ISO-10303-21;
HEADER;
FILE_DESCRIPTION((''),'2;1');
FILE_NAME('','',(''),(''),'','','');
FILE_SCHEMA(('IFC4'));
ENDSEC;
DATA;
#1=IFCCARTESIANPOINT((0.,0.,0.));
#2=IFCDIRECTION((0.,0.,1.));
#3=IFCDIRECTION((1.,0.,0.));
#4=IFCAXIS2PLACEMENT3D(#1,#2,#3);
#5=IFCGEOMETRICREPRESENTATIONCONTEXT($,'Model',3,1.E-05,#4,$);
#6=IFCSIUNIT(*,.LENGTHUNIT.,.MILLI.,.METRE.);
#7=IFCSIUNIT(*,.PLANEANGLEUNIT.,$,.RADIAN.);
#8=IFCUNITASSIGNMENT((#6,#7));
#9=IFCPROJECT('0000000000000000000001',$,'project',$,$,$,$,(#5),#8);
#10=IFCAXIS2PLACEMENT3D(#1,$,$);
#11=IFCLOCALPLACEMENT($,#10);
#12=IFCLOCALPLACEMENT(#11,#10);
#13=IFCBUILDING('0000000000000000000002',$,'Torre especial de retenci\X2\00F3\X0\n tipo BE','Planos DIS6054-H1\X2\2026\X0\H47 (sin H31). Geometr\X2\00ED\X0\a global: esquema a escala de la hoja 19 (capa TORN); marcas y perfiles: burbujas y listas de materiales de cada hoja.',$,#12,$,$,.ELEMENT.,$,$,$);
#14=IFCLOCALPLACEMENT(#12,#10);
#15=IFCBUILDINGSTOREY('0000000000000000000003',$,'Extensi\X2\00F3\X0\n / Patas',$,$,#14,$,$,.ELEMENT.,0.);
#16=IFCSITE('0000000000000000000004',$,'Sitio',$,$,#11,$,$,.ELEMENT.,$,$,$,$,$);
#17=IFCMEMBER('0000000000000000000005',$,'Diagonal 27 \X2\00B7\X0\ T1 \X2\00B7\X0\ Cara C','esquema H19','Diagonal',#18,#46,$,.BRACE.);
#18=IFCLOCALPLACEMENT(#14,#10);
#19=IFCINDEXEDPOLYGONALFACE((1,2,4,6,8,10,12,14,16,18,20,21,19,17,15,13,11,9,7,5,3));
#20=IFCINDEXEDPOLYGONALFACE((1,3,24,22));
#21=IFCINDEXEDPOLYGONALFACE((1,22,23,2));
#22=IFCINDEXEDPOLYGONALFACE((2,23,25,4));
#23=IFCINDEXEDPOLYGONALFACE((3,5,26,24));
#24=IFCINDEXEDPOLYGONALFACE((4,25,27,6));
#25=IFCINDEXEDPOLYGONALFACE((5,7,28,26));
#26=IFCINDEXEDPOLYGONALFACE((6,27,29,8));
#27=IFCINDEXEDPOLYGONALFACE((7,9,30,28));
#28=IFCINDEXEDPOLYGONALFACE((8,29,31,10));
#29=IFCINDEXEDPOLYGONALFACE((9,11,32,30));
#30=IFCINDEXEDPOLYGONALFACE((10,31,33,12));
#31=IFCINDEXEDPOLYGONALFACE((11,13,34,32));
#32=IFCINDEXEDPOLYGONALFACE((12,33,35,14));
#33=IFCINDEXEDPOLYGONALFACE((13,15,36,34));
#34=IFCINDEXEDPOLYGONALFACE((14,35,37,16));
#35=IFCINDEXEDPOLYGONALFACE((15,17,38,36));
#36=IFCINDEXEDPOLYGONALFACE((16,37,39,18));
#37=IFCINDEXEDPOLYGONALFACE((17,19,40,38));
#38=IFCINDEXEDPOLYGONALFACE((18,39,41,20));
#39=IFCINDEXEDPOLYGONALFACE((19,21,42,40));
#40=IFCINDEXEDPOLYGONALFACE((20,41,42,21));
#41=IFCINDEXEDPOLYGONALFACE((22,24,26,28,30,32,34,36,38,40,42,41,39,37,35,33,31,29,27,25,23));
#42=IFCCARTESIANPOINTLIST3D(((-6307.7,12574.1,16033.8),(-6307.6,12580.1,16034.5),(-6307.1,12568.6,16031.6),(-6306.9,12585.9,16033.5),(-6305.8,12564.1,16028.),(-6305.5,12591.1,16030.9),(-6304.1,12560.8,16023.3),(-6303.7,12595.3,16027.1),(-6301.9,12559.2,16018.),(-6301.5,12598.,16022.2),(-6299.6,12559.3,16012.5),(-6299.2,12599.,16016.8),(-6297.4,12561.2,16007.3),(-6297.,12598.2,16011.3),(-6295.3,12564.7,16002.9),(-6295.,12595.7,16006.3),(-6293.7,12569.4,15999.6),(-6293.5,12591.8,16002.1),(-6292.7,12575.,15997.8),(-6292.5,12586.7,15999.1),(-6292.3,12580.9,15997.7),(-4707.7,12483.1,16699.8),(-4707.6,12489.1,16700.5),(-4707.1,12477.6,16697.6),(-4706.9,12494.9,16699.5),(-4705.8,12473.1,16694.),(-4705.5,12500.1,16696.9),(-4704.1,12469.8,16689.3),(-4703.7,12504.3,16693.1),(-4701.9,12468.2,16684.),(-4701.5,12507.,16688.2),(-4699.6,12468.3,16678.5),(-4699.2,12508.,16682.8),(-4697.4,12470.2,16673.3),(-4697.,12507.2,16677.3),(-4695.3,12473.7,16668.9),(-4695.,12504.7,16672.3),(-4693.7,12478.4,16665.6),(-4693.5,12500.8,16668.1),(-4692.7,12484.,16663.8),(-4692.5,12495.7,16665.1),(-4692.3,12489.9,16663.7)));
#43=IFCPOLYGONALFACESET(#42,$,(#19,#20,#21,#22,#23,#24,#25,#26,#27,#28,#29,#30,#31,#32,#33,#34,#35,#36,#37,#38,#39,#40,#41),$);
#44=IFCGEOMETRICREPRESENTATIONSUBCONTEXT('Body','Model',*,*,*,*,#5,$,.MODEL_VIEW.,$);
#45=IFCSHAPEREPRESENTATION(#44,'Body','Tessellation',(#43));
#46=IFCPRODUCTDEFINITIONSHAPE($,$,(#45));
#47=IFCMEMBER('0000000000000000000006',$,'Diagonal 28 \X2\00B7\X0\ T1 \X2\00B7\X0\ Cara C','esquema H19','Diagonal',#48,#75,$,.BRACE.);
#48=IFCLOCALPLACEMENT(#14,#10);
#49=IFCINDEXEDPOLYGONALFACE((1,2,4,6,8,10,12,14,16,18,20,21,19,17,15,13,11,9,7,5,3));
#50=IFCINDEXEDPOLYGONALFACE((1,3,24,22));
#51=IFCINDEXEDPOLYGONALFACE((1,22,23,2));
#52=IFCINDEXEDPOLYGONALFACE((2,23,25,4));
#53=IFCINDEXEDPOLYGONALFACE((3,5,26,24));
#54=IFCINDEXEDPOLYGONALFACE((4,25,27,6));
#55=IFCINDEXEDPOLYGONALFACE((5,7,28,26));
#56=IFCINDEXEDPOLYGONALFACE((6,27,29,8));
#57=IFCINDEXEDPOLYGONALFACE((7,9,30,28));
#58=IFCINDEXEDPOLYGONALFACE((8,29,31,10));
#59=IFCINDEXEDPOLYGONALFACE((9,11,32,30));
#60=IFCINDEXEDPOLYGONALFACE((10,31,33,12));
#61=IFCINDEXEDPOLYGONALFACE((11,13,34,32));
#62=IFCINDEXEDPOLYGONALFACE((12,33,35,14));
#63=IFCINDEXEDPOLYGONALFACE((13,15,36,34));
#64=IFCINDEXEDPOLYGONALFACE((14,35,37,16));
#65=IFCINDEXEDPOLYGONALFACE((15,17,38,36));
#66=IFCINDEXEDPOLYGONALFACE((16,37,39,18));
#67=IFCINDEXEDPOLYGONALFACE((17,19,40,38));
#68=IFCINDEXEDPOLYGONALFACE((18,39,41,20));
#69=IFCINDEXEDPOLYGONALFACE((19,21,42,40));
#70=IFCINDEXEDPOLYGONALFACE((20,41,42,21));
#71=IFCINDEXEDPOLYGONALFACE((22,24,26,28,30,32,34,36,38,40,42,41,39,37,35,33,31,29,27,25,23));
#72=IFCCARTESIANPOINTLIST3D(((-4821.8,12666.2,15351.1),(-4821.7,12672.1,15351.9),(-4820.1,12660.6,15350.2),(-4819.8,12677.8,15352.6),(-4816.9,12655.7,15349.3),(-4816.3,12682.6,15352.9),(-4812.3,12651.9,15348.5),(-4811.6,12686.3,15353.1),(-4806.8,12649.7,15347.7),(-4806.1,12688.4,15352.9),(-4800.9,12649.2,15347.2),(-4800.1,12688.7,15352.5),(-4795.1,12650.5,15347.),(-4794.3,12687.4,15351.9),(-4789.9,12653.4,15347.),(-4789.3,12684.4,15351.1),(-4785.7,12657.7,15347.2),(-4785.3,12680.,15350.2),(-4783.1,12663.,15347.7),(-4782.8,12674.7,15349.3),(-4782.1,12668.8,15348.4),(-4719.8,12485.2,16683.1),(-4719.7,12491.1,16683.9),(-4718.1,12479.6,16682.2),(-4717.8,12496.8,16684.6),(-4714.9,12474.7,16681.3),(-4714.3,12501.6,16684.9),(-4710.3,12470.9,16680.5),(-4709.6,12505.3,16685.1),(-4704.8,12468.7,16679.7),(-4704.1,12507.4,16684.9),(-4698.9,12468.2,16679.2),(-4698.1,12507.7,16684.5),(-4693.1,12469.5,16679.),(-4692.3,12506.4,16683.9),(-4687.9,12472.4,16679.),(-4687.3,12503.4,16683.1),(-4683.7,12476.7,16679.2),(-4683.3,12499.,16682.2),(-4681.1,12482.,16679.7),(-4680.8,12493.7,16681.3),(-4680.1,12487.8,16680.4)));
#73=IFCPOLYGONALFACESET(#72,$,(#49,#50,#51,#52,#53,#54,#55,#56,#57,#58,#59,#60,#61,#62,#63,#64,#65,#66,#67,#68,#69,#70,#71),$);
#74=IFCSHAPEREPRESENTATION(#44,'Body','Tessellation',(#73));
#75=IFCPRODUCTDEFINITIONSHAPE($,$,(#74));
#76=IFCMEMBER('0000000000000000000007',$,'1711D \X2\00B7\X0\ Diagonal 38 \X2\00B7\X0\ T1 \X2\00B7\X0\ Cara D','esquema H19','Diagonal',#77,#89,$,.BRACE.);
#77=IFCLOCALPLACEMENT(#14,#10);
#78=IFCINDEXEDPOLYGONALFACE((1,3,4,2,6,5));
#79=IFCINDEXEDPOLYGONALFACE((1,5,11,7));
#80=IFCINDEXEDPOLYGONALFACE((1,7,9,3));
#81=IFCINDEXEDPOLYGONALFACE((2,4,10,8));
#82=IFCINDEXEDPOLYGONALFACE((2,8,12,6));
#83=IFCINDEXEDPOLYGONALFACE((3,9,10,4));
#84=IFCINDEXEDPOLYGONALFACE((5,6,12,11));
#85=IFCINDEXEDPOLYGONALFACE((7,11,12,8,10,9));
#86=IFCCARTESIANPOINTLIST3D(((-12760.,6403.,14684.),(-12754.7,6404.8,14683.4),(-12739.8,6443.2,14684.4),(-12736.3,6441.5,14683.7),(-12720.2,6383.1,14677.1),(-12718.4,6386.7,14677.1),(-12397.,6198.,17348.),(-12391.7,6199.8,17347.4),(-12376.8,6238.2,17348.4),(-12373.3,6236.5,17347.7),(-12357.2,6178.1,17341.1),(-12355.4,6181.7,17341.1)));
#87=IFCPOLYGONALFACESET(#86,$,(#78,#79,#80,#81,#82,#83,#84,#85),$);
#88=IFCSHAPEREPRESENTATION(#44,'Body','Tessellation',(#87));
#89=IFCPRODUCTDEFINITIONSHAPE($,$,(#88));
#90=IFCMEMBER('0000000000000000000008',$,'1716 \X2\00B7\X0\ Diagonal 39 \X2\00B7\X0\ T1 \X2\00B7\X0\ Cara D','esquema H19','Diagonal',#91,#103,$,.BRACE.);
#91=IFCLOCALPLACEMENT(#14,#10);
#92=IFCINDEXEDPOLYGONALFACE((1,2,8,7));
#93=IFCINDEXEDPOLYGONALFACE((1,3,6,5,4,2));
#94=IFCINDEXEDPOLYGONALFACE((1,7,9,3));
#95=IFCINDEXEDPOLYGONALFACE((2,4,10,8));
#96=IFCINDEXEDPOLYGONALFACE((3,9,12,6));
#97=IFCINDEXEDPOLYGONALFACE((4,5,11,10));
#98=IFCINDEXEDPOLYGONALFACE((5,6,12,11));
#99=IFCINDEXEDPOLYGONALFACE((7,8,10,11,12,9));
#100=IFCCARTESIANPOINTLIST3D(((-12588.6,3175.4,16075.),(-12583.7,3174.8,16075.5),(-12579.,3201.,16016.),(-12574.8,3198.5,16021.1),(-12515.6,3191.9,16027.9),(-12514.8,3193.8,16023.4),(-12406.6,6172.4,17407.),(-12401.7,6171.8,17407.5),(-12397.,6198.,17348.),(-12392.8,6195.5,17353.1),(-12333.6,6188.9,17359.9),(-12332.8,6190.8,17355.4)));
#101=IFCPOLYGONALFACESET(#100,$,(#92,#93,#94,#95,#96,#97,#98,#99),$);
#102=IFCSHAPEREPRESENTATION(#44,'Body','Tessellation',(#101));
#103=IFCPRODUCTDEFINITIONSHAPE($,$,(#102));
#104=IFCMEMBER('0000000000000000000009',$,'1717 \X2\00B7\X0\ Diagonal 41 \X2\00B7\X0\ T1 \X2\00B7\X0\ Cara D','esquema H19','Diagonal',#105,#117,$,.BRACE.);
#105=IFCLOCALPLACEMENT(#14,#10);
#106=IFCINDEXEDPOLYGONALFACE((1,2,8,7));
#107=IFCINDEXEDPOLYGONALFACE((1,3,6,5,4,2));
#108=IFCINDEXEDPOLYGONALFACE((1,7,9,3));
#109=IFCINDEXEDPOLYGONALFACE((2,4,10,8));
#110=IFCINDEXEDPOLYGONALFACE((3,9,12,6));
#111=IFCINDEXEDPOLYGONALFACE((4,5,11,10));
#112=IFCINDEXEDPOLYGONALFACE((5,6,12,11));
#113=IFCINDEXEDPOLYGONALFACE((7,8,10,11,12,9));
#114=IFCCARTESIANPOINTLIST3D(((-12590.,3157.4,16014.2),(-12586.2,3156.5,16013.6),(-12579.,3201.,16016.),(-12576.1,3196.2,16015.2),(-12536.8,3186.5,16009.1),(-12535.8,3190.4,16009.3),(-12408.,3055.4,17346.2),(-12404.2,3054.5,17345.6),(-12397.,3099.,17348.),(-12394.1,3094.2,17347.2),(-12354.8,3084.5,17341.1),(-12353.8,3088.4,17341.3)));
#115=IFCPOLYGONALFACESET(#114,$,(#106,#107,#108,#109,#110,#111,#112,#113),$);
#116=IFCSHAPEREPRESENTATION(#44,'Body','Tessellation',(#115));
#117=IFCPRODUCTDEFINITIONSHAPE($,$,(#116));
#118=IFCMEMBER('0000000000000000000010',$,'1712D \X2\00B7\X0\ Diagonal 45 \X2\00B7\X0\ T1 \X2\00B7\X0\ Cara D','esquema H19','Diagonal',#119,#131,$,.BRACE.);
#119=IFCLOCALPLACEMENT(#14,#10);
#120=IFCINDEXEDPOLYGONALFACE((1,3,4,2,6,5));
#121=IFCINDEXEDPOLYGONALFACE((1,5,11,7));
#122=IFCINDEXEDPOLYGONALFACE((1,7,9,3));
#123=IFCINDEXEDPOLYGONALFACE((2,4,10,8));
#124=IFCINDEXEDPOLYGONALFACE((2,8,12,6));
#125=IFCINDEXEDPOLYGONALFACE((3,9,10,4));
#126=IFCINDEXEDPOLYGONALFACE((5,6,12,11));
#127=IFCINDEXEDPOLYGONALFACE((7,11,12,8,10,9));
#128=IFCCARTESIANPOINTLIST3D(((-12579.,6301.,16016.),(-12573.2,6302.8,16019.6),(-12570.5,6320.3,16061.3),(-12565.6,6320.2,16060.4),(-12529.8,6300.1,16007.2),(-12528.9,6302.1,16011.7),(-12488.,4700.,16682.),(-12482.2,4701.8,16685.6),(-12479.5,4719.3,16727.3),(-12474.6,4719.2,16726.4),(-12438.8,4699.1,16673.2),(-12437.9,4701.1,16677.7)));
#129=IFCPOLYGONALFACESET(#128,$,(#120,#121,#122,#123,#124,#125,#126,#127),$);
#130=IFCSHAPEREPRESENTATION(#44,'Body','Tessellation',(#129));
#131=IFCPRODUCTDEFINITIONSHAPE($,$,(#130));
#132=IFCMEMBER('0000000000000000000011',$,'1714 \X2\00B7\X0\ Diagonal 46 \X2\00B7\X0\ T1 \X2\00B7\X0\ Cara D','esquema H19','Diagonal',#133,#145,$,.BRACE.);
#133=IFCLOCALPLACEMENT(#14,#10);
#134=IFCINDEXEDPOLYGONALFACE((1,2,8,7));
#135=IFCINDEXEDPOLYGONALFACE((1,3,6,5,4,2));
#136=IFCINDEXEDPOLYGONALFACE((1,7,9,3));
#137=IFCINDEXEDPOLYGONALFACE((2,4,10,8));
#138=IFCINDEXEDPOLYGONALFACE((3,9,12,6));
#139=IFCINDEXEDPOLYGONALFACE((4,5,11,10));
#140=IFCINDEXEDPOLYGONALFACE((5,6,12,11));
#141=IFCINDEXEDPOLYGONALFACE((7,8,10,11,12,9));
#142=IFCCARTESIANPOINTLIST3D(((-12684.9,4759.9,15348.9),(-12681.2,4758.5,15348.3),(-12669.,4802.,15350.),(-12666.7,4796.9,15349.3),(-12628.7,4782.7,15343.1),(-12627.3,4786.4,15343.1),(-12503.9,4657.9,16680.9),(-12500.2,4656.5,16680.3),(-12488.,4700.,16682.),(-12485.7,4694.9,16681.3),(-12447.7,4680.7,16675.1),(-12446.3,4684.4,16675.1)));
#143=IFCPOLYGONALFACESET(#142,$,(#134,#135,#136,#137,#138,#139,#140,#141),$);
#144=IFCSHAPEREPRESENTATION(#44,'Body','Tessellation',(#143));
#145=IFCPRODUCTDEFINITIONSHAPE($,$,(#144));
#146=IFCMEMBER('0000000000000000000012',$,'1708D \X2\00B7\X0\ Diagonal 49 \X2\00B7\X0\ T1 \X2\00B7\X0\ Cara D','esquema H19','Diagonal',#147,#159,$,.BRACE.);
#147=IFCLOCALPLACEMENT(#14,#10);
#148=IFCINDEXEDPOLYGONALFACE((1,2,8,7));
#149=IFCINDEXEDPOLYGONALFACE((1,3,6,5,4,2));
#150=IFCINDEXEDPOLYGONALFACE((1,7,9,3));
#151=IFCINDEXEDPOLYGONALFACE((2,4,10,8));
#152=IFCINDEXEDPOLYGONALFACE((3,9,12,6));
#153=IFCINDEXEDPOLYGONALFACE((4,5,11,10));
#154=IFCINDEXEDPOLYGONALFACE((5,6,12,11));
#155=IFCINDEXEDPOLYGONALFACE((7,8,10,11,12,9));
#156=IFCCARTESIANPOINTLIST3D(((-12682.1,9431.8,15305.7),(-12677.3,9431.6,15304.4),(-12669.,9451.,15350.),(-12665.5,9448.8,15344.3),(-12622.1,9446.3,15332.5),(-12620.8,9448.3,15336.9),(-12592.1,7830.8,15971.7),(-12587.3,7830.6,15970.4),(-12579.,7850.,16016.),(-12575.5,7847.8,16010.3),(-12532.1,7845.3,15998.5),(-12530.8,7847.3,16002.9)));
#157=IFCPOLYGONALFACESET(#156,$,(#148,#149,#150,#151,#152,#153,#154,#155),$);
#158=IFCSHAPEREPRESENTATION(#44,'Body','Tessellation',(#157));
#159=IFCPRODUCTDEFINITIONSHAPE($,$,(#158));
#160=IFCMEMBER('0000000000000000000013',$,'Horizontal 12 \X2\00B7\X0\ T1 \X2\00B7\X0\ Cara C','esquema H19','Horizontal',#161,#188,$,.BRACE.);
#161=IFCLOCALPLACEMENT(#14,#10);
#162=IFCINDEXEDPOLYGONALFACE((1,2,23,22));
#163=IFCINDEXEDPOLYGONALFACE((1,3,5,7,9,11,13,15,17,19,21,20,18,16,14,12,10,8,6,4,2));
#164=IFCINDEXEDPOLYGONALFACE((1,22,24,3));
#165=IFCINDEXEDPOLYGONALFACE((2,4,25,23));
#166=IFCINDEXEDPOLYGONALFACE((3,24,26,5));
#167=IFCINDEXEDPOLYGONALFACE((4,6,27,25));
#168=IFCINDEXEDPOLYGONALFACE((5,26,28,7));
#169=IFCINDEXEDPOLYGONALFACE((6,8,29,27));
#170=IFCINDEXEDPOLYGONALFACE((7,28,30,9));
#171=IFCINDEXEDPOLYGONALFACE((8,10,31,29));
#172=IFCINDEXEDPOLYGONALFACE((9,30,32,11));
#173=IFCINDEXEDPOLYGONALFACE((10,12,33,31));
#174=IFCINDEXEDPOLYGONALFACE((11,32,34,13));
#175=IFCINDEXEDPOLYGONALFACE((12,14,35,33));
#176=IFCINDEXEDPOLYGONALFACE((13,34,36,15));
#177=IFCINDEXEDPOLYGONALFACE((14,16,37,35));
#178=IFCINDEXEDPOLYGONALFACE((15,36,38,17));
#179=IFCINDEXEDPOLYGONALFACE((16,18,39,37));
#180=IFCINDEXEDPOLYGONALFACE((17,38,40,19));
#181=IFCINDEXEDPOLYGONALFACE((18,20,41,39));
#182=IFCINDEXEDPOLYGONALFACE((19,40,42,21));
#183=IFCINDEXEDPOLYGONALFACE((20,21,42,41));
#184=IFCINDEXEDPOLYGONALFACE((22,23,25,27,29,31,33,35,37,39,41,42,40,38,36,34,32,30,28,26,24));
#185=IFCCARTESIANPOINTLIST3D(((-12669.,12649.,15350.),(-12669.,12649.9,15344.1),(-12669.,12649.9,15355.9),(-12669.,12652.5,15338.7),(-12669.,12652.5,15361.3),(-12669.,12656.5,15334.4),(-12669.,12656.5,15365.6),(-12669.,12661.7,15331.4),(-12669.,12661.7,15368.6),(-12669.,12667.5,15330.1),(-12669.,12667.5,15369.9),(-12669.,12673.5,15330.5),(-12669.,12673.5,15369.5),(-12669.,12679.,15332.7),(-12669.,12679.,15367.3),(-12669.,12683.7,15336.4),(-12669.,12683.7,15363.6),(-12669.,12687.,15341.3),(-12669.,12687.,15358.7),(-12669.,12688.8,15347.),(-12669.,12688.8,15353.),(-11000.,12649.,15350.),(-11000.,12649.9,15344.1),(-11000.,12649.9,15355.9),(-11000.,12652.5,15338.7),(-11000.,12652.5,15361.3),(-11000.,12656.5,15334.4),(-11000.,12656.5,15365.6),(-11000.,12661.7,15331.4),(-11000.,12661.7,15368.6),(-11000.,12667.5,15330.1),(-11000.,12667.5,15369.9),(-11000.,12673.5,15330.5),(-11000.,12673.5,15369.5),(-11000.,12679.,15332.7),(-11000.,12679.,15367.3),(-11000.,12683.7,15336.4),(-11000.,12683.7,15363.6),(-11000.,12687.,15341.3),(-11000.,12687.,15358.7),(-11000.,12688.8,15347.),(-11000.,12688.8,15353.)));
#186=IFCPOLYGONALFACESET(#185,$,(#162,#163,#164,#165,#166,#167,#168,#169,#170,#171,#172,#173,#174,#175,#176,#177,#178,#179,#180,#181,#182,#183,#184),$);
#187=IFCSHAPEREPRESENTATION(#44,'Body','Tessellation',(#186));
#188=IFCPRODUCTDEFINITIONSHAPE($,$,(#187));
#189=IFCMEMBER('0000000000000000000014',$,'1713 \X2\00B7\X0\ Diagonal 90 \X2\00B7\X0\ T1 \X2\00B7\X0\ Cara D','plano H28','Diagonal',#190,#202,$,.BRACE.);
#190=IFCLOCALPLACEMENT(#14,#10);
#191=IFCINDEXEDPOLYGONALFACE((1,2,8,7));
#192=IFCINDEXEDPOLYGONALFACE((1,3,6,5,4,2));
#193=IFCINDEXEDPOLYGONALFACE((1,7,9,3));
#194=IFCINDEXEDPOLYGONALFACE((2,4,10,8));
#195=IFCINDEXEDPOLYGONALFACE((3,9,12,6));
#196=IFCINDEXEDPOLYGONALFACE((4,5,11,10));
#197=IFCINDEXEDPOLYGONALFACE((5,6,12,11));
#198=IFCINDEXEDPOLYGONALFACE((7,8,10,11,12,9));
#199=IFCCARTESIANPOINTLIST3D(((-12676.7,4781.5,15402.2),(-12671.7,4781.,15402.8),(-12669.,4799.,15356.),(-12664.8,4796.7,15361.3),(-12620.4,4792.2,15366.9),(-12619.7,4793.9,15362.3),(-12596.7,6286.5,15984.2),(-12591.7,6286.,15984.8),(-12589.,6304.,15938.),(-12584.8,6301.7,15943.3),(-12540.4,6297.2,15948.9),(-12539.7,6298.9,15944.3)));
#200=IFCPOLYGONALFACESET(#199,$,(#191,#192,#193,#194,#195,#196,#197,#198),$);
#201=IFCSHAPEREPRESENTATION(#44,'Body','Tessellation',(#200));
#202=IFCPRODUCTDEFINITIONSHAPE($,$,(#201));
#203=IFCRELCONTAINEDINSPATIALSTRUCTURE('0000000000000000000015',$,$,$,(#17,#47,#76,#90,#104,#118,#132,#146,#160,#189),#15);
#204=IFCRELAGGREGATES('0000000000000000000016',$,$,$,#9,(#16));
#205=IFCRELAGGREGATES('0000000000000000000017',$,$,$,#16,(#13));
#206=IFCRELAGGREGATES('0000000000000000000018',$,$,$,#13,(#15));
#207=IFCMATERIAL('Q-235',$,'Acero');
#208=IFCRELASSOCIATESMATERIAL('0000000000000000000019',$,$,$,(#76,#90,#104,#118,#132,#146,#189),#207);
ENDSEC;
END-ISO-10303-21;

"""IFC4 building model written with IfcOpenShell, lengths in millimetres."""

from ifc_helpers import new_model, si_unit, frame, frame_2d, origin, origin_with_axes, place, context, subcontext, project, spatial, circle, l_section, extrude, material, element, save


model = new_model("IFC4")

# Units and contexts
model_context = context("Model", 3, precision=1e-05, world=origin_with_axes())
body_context = subcontext(model_context, "Body", "Model", "MODEL_VIEW")
ifc_project = project(units=[si_unit("LENGTHUNIT", "METRE", prefix="MILLI"), si_unit("PLANEANGLEUNIT", "RADIAN")], contexts=[model_context])

# Site, building, storey
site_placement = place(None, origin())
site = spatial("IfcSite", under=ifc_project, at=site_placement, Name="Sitio", CompositionType="ELEMENT")
building_placement = place(site_placement, origin())
building = spatial("IfcBuilding", under=site, at=building_placement, Name="Torre especial de retención tipo BE", Description="Planos DIS6054-H1…H47 (sin H31). Geometría global: esquema a escala de la hoja 19 (capa TORN); marcas y perfiles: burbujas y listas de materiales de cada hoja.", CompositionType="ELEMENT")
storey_placement = place(building_placement, origin())
storey = spatial("IfcBuildingStorey", under=building, at=storey_placement, Name="Extensión / Patas", CompositionType="ELEMENT", Elevation=0.0)

# Members
ifc_material = material(Name="Q-235", Category="Acero")
member_1_placement = place(storey_placement, frame((-6300.0, 12579.0, 16016.0), z_axis=(0.921943, -0.052436, 0.383759), x_axis=(0.017634, -0.984084, -0.176826)))
element("IfcMember", 1, at=member_1_placement, inside=storey, Name="Diagonal 27 · T1 · Cara C", Description="esquema H19", ObjectType="Diagonal", PredefinedType="BRACE", context=body_context, shape_type="SweptSolid", body=[
    extrude(circle(Radius=20.0), None, (0.0, 0.0, 1.0), 1735.5),
])
member_2_placement = place(storey_placement, frame((-4700.0, 12488.0, 16682.0), z_axis=(-0.075662, 0.134262, -0.988053), x_axis=(0.345854, -0.925846, -0.152294)))
element("IfcMember", 2, at=member_2_placement, inside=storey, Name="Diagonal 28 · T1 · Cara C", Description="esquema H19", ObjectType="Diagonal", PredefinedType="BRACE", context=body_context, shape_type="SweptSolid", body=[
    extrude(circle(Radius=20.0), None, (0.0, 0.0, 1.0), 1348.1),
])
member_3_placement = place(storey_placement, frame((-12760.0, 6403.0, 14684.0), z_axis=(0.134623, -0.076027, 0.987976), x_axis=(0.883921, -0.441408, -0.154411)))
element("IfcMember", 3, at=member_3_placement, inside=storey, material=ifc_material, Name="1711D · Diagonal 38 · T1 · Cara D", Description="esquema H19", ObjectType="Diagonal", PredefinedType="BRACE", context=body_context, shape_type="SweptSolid", body=[
    extrude(l_section(Depth=45.0, Width=45.0, Thickness=4.0, at=frame_2d((22.5, 22.5))), None, (0.0, 0.0, 1.0), 2696.4),
])
member_4_placement = place(storey_placement, frame((-12397.0, 6198.0, 17348.0), z_axis=(-0.055408, -0.912408, -0.405515), x_axis=(0.987387, -0.110399, 0.113485)))
element("IfcMember", 4, at=member_4_placement, inside=storey, material=ifc_material, Name="1716 · Diagonal 39 · T1 · Cara D", Description="esquema H19", ObjectType="Diagonal", PredefinedType="BRACE", context=body_context, shape_type="SweptSolid", body=[
    extrude(l_section(Depth=65.0, Width=65.0, Thickness=5.0, at=frame_2d((32.5, 32.5))), None, (0.0, 0.0, 1.0), 3284.7),
])
member_5_placement = place(storey_placement, frame((-12397.0, 3099.0, 17348.0), z_axis=(-0.134991, 0.075654, -0.987954), x_axis=(0.960238, -0.235927, -0.14927)))
element("IfcMember", 5, at=member_5_placement, inside=storey, material=ifc_material, Name="1717 · Diagonal 41 · T1 · Cara D", Description="esquema H19", ObjectType="Diagonal", PredefinedType="BRACE", context=body_context, shape_type="SweptSolid", body=[
    extrude(l_section(Depth=45.0, Width=45.0, Thickness=4.0, at=frame_2d((22.5, 22.5))), None, (0.0, 0.0, 1.0), 1348.2),
])
member_6_placement = place(storey_placement, frame((-12579.0, 6301.0, 16016.0), z_axis=(0.052408, -0.92203, 0.383555), x_axis=(0.984098, -0.017591, -0.176751)))
element("IfcMember", 6, at=member_6_placement, inside=storey, material=ifc_material, Name="1712D · Diagonal 45 · T1 · Cara D", Description="esquema H19", ObjectType="Diagonal", PredefinedType="BRACE", context=body_context, shape_type="SweptSolid", body=[
    extrude(l_section(Depth=50.0, Width=50.0, Thickness=5.0, at=frame_2d((25.0, 25.0))), None, (0.0, 0.0, 1.0), 1736.4),
])
member_7_placement = place(storey_placement, frame((-12488.0, 4700.0, 16682.0), z_axis=(-0.134262, 0.075662, -0.988053), x_axis=(0.925846, -0.345854, -0.152294)))
element("IfcMember", 7, at=member_7_placement, inside=storey, material=ifc_material, Name="1714 · Diagonal 46 · T1 · Cara D", Description="esquema H19", ObjectType="Diagonal", PredefinedType="BRACE", context=body_context, shape_type="SweptSolid", body=[
    extrude(l_section(Depth=45.0, Width=45.0, Thickness=4.0, at=frame_2d((22.5, 22.5))), None, (0.0, 0.0, 1.0), 1348.1),
])
member_8_placement = place(storey_placement, frame((-12579.0, 7850.0, 16016.0), z_axis=(-0.051833, 0.922057, -0.383567), x_axis=(0.963524, -0.054804, -0.261949)))
element("IfcMember", 8, at=member_8_placement, inside=storey, material=ifc_material, Name="1708D · Diagonal 49 · T1 · Cara D", Description="esquema H19", ObjectType="Diagonal", PredefinedType="BRACE", context=body_context, shape_type="SweptSolid", body=[
    extrude(l_section(Depth=50.0, Width=50.0, Thickness=5.0, at=frame_2d((25.0, 25.0))), None, (0.0, 0.0, 1.0), 1736.3),
])
member_9_placement = place(storey_placement, frame((-11000.0, 12669.0, 15350.0), z_axis=(-1.0, 0.0, 0.0), x_axis=(0.0, -1.0, 0.0)))
element("IfcMember", 9, at=member_9_placement, inside=storey, Name="Horizontal 12 · T1 · Cara C", Description="esquema H19", ObjectType="Horizontal", PredefinedType="BRACE", context=body_context, shape_type="SweptSolid", body=[
    extrude(circle(Radius=20.0), None, (0.0, 0.0, 1.0), 1669.0),
])
member_10_placement = place(storey_placement, frame((-12589.0, 6304.0, 15938.0), z_axis=(-0.049517, -0.931545, -0.360239), x_axis=(0.9869, -0.101084, 0.125737)))
element("IfcMember", 10, at=member_10_placement, inside=storey, material=ifc_material, Name="1713 · Diagonal 90 · T1 · Cara D", Description="plano H28", ObjectType="Diagonal", PredefinedType="BRACE", context=body_context, shape_type="SweptSolid", body=[
    extrude(l_section(Depth=50.0, Width=50.0, Thickness=5.0, at=frame_2d((25.0, 25.0))), None, (0.0, 0.0, 1.0), 1615.6),
])

save(model, "model.ifc")
